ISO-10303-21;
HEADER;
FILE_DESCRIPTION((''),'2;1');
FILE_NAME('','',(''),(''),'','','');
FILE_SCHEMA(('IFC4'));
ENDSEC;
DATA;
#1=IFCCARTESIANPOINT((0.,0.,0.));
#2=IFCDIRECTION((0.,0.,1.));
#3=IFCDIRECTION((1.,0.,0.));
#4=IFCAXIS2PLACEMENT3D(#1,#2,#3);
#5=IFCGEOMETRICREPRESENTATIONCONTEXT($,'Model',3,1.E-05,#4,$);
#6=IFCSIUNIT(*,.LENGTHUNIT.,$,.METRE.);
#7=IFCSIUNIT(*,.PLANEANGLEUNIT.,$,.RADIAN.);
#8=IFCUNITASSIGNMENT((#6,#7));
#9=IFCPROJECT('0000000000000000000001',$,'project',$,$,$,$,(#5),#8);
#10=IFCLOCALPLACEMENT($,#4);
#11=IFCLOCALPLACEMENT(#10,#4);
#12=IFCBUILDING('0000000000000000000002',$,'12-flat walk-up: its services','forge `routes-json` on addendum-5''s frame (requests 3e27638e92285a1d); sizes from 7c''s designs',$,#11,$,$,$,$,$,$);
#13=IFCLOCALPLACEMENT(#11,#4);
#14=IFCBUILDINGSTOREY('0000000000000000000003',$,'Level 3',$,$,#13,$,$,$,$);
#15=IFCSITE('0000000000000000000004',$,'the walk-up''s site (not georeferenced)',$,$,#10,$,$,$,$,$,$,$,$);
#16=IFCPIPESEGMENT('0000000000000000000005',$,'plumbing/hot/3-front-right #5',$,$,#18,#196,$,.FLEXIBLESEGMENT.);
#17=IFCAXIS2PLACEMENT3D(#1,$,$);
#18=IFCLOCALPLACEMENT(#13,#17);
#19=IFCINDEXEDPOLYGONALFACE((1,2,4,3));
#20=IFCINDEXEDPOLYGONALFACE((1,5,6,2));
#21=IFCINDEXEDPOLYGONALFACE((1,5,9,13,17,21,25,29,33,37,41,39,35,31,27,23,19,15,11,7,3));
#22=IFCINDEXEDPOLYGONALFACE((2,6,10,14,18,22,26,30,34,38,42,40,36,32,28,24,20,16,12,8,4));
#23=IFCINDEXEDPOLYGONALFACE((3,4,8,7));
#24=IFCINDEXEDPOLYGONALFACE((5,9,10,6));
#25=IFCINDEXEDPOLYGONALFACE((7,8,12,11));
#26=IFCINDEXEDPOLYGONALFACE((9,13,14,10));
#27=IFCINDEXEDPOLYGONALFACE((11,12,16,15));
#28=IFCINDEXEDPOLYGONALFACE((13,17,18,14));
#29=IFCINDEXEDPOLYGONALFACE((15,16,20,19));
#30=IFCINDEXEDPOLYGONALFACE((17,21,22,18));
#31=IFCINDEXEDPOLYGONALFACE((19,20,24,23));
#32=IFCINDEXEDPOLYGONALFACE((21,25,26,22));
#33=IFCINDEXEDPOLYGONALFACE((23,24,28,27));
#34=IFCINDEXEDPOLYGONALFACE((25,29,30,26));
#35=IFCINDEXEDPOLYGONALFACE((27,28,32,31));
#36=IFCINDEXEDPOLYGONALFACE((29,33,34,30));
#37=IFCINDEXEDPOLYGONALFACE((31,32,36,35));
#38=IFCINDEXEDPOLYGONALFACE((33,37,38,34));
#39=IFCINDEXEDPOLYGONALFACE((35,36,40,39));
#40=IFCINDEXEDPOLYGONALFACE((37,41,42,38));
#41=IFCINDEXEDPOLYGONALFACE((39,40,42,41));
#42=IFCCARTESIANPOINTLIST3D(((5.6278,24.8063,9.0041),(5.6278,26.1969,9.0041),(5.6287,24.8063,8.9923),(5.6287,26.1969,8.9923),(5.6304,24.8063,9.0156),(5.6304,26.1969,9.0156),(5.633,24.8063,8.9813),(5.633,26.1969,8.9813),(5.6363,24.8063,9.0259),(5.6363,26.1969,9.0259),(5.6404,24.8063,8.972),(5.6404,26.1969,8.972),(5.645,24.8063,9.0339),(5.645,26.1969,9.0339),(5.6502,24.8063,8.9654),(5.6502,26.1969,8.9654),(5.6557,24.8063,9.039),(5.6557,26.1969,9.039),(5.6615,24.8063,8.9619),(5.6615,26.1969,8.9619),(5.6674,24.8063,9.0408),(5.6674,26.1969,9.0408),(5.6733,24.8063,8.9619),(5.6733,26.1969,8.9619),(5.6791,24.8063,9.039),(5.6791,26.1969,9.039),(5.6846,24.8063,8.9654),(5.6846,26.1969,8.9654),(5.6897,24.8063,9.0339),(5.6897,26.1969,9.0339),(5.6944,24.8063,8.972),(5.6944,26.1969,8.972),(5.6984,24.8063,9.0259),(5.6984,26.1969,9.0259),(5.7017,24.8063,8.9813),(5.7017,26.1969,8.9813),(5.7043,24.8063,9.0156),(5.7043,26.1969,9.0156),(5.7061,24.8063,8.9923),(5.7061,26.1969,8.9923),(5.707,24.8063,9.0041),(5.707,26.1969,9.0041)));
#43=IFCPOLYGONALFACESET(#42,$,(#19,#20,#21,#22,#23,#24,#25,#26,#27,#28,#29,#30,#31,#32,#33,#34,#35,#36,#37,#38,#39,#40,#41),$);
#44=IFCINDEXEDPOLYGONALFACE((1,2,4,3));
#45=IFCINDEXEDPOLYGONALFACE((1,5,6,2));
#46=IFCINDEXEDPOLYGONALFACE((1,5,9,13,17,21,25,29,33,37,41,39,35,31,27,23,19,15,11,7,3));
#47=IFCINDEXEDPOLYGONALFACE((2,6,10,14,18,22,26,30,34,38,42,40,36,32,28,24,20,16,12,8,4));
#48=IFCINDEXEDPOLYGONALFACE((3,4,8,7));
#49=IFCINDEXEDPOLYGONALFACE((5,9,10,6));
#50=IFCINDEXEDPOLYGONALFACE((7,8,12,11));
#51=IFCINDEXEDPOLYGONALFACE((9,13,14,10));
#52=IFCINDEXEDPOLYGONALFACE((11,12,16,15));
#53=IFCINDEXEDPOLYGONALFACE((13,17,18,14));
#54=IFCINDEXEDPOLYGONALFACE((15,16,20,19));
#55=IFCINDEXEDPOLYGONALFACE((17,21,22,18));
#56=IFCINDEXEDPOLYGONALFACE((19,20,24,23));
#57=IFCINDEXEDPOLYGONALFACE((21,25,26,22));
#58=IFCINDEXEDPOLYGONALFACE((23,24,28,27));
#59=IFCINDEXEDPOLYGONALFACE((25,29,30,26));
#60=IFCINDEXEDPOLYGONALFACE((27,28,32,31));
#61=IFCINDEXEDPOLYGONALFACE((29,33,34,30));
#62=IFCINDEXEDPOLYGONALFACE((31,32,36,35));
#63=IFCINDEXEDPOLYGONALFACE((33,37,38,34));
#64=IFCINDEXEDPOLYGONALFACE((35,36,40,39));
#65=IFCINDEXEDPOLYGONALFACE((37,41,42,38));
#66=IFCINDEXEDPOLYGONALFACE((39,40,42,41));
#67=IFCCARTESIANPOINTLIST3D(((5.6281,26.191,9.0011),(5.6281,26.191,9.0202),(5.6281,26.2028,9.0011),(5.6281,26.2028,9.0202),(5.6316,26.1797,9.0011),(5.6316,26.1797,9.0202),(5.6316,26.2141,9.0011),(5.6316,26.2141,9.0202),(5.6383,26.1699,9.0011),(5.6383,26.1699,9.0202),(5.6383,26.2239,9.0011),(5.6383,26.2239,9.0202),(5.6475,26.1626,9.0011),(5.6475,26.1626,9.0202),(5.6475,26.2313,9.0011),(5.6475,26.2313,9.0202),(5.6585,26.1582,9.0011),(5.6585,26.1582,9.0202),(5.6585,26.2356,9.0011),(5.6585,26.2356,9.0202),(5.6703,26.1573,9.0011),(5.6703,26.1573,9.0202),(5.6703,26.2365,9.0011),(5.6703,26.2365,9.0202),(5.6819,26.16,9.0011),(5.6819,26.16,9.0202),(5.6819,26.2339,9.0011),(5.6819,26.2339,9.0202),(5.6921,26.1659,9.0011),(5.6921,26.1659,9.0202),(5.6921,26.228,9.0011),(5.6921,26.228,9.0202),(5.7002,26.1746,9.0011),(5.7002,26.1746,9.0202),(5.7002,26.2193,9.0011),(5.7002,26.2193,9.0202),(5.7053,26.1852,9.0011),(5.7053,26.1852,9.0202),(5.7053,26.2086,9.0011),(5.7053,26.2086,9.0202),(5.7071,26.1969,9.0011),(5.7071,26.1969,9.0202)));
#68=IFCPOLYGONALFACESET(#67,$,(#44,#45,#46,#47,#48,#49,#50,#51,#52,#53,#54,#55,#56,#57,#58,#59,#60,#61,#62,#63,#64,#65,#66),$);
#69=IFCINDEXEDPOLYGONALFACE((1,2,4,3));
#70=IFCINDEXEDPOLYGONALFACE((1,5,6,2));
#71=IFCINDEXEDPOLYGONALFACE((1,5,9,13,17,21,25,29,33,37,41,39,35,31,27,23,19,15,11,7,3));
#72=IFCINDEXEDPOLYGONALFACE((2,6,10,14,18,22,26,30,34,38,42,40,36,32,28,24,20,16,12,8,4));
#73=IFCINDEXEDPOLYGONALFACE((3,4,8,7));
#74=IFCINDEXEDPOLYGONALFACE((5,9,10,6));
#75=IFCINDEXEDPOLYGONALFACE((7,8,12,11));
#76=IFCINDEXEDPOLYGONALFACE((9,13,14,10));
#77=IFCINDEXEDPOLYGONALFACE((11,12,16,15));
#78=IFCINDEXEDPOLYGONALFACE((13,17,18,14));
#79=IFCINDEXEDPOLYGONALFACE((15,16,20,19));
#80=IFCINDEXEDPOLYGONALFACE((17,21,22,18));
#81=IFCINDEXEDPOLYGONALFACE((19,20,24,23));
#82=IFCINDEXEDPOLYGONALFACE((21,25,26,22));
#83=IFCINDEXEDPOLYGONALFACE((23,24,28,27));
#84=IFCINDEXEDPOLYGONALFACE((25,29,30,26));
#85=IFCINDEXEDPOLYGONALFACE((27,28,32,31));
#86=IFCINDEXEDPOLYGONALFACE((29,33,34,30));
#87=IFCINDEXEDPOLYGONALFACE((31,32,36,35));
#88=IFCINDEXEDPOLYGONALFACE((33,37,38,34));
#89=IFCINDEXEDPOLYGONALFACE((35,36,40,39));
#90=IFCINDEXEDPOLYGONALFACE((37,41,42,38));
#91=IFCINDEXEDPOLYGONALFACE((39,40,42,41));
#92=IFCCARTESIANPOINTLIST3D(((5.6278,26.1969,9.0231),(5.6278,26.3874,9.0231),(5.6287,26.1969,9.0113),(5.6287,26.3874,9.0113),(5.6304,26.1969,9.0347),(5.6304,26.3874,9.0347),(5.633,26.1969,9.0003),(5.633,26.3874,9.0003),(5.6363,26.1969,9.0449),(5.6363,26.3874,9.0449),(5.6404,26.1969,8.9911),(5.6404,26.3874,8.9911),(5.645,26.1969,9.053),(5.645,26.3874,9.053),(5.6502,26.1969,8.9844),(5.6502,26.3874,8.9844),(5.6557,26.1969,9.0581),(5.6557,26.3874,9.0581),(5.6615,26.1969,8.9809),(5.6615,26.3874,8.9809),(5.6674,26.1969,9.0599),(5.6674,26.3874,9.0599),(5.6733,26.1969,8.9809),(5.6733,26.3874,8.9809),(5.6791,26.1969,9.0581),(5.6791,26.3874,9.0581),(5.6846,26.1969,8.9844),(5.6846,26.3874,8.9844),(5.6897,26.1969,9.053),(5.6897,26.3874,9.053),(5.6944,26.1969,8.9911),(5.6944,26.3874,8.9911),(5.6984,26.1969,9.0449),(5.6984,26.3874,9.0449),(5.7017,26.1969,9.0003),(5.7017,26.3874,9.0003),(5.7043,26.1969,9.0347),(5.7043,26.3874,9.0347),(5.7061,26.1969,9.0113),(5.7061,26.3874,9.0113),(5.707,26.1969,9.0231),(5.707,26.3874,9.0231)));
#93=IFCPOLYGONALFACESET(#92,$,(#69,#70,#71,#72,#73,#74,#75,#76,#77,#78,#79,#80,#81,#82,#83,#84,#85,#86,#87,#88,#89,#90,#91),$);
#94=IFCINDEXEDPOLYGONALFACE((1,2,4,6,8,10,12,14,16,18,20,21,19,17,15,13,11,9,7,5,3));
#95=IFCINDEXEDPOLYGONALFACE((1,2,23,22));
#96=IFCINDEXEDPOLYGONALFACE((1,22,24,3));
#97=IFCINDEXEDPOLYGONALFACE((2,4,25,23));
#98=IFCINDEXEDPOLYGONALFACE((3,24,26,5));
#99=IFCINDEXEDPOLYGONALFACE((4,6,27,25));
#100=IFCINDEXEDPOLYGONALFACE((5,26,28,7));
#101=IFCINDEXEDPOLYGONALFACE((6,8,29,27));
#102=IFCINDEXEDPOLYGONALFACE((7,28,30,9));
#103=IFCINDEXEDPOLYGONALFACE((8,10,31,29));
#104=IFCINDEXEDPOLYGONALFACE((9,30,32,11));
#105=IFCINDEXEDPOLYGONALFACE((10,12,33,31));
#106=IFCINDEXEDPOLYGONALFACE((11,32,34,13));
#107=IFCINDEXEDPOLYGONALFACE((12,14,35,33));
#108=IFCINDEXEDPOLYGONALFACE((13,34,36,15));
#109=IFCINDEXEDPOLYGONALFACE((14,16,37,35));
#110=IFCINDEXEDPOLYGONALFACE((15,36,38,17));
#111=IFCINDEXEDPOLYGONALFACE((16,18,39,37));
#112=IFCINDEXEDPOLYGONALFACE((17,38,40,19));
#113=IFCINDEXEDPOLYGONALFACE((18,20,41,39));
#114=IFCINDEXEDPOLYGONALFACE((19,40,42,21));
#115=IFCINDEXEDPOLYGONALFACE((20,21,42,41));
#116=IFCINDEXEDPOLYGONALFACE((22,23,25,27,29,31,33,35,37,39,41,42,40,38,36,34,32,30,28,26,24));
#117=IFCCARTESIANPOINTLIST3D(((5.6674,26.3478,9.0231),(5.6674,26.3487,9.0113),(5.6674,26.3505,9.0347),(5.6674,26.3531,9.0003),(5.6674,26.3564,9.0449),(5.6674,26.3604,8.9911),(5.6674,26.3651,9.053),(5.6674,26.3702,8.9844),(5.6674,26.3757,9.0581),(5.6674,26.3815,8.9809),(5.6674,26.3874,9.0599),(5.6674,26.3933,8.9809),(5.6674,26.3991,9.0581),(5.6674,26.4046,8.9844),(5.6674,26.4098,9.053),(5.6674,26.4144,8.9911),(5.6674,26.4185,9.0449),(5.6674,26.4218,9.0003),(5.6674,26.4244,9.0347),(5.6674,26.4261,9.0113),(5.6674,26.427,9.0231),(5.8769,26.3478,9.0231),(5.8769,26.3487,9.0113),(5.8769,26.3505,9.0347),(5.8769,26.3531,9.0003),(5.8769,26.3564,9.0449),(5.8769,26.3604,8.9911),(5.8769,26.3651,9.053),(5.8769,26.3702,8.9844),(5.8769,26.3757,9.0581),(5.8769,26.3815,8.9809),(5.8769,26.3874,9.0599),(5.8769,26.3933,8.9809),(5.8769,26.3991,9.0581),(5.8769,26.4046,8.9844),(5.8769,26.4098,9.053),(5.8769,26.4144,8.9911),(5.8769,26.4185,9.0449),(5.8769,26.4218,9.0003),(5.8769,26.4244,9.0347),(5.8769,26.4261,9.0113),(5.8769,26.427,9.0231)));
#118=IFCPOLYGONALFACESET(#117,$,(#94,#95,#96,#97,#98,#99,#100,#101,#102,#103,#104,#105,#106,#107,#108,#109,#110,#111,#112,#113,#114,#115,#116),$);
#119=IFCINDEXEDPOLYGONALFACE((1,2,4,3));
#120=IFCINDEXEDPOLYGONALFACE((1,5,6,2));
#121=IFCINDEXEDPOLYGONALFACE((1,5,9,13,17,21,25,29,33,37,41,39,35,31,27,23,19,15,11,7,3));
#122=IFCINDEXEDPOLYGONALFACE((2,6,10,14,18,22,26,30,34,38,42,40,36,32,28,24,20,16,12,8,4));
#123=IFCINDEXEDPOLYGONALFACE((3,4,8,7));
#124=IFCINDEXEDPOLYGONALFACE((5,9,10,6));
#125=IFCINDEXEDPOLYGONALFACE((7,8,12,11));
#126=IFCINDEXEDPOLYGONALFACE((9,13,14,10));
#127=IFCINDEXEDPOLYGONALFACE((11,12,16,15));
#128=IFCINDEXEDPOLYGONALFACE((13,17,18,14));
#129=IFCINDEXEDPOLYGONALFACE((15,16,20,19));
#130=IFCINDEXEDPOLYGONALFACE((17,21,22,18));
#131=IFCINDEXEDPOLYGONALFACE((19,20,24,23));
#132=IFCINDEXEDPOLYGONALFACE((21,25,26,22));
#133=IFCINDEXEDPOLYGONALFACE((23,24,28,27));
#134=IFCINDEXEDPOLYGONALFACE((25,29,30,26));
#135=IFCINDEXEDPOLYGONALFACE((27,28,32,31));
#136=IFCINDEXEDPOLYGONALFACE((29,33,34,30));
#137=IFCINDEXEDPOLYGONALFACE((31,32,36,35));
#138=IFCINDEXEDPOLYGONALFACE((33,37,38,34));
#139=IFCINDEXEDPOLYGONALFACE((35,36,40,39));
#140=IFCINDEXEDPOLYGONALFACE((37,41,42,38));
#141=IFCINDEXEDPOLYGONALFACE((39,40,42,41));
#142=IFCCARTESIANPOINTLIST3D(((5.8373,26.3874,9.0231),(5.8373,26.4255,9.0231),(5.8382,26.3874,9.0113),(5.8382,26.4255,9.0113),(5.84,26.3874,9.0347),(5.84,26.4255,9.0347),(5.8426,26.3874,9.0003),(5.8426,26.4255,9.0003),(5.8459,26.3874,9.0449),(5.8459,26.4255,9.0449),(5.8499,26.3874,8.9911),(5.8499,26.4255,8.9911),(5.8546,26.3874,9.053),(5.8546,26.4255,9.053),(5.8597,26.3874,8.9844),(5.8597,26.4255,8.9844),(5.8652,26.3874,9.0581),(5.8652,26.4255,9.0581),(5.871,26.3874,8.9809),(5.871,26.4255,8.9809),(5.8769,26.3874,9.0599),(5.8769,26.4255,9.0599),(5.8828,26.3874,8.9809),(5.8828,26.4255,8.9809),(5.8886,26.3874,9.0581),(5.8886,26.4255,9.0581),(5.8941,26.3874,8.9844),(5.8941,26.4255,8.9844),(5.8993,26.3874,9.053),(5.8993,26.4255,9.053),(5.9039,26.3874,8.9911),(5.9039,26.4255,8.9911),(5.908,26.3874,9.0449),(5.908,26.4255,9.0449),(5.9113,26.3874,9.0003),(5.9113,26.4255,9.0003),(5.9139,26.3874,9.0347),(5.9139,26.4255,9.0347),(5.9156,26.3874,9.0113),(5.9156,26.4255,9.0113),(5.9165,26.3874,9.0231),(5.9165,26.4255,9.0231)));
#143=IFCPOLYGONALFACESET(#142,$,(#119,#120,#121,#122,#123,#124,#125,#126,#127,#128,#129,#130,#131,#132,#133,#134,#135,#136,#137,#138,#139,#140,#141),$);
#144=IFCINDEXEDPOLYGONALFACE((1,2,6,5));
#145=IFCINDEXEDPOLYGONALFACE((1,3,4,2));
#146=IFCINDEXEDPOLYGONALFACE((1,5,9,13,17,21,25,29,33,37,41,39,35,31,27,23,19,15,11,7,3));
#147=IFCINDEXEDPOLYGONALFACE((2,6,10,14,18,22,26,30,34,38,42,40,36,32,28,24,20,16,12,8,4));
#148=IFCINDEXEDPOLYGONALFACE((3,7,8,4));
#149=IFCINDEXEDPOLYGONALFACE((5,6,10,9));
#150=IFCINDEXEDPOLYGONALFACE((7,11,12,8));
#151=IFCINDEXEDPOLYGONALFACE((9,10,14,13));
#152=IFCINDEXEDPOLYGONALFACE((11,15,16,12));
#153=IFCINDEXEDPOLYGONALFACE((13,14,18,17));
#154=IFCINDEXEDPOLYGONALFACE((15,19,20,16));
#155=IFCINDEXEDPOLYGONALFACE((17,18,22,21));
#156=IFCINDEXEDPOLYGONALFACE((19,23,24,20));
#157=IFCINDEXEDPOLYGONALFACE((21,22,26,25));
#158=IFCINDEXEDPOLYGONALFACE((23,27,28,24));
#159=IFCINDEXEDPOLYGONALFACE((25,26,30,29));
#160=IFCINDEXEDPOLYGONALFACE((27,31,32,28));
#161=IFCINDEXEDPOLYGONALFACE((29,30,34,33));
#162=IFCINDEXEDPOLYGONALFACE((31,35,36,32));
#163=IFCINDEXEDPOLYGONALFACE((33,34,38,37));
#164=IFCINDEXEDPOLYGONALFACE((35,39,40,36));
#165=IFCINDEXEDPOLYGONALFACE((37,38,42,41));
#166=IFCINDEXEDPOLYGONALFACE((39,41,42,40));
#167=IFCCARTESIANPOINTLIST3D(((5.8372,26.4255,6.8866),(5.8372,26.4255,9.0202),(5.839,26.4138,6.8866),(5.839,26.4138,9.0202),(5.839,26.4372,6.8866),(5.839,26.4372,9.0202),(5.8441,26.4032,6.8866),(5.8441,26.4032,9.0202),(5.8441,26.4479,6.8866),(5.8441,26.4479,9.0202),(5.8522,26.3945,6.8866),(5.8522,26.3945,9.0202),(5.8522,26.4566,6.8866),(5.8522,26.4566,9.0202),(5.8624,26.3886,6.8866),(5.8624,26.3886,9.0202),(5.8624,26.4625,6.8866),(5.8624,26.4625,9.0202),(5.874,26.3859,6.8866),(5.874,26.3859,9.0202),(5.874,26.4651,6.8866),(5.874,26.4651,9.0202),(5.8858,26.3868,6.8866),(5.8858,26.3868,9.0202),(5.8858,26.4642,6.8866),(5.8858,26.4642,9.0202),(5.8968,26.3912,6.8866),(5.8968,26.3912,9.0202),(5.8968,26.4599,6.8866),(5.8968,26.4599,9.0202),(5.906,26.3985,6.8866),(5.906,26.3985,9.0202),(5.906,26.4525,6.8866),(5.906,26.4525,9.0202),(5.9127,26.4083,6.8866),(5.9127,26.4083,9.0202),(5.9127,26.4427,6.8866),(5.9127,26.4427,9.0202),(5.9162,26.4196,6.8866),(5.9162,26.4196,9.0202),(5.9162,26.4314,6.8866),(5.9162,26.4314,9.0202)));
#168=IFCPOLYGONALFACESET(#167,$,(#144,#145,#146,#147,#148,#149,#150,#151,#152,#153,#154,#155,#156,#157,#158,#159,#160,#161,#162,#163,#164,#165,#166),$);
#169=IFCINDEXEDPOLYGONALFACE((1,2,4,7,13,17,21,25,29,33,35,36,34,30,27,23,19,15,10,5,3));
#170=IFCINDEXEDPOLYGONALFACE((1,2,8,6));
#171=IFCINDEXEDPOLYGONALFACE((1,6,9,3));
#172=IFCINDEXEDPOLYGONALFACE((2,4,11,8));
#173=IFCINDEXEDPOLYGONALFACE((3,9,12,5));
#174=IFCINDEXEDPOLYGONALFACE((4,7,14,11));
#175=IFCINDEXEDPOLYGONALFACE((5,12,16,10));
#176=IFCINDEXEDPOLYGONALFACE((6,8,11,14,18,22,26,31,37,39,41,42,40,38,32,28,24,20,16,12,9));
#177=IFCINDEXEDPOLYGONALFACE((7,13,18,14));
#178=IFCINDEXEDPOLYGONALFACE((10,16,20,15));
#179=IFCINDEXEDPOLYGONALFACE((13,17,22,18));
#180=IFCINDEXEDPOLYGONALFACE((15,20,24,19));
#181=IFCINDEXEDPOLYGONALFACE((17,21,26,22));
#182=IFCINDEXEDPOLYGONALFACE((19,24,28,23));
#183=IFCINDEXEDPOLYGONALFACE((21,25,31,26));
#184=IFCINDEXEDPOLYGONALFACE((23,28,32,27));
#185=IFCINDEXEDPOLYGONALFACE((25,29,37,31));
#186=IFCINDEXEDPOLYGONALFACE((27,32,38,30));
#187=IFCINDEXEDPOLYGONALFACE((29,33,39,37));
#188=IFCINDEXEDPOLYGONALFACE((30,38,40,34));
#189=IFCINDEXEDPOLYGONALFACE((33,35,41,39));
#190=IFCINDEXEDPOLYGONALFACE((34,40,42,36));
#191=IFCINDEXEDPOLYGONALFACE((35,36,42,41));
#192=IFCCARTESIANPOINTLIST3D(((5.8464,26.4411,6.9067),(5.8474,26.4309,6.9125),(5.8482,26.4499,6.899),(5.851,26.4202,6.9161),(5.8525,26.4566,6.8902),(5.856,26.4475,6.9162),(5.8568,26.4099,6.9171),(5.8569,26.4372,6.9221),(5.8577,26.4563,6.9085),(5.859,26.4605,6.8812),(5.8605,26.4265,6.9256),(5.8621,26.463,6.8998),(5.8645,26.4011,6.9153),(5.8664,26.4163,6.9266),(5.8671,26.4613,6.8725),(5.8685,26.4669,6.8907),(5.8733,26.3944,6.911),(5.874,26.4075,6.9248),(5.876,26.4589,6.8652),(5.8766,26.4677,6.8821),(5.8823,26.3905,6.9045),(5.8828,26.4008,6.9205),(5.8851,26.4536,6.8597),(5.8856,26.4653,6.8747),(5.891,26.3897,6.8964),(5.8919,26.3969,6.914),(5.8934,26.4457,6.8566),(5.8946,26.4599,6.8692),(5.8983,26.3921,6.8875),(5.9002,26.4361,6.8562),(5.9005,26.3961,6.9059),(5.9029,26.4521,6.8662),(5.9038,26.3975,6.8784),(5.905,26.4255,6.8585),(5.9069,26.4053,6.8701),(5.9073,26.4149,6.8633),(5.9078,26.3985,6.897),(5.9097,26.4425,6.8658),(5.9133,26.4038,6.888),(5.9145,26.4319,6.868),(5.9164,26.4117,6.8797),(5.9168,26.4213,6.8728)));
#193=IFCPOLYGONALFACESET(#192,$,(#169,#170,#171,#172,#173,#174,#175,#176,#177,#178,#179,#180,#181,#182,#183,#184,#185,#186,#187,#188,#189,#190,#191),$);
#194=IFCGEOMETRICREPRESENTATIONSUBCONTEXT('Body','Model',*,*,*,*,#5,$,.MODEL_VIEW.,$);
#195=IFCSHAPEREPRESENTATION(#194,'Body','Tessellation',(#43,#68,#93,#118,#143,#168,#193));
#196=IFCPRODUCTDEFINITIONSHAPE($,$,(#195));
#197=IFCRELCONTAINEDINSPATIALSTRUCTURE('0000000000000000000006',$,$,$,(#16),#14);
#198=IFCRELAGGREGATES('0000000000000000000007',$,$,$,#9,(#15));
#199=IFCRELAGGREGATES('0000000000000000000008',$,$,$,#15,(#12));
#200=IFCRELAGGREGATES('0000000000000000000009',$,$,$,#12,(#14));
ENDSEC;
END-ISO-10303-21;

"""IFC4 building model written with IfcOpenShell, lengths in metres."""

from ifc_helpers import new_model, entity, si_unit, frame, origin_with_axes, place, context, subcontext, project, spatial, element, save


model = new_model("IFC4")

# Units and contexts
model_context = context("Model", 3, precision=1e-05, world=origin_with_axes())
body_context = subcontext(model_context, "Body", "Model", "MODEL_VIEW")
ifc_project = project(units=[si_unit("LENGTHUNIT", "METRE"), si_unit("PLANEANGLEUNIT", "RADIAN")], contexts=[model_context])

# Site, building, storey
site_placement = place(None, origin_with_axes())
site = spatial("IfcSite", under=ifc_project, at=site_placement, Name="the walk-up's site (not georeferenced)")
building_placement = place(site_placement, origin_with_axes())
building = spatial("IfcBuilding", under=site, at=building_placement, Name="12-flat walk-up: its services", Description="forge `routes-json` on addendum-5's frame (requests 3e27638e92285a1d); sizes from 7c's designs")
storey_placement = place(building_placement, origin_with_axes())
storey = spatial("IfcBuildingStorey", under=building, at=storey_placement, Name="Level 3")

# Pipe segment
pipe_segment_1_placement = place(storey_placement, frame((5.6674, 24.8063, 9.0011), z_axis=(0.0, 0.0, 1.0), x_axis=(1.0, 0.0, 0.0)))
element("IfcPipeSegment", 1, at=pipe_segment_1_placement, inside=storey, Name="plumbing/hot/3-front-right #5", PredefinedType="FLEXIBLESEGMENT", context=body_context, shape_type="AdvancedSweptSolid", body=[
    entity("IfcSweptDiskSolid", entity("IfcPolyline", [entity("IfcCartesianPoint", [0.0, 0.0, 0.0]), entity("IfcCartesianPoint", [0.0, 1.3906, 0.0])]), 0.0397),
    entity("IfcSweptDiskSolid", entity("IfcPolyline", [entity("IfcCartesianPoint", [0.0, 1.3906, 0.0]), entity("IfcCartesianPoint", [0.0, 1.3906, 0.0191])]), 0.0397),
    entity("IfcSweptDiskSolid", entity("IfcPolyline", [entity("IfcCartesianPoint", [0.0, 1.3906, 0.0191]), entity("IfcCartesianPoint", [0.0, 1.5811, 0.0191])]), 0.0397),
    entity("IfcSweptDiskSolid", entity("IfcPolyline", [entity("IfcCartesianPoint", [0.0, 1.5811, 0.0191]), entity("IfcCartesianPoint", [0.2096, 1.5811, 0.0191])]), 0.0397),
    entity("IfcSweptDiskSolid", entity("IfcPolyline", [entity("IfcCartesianPoint", [0.2096, 1.5811, 0.0191]), entity("IfcCartesianPoint", [0.2096, 1.6192, 0.0191])]), 0.0397),
    entity("IfcSweptDiskSolid", entity("IfcPolyline", [entity("IfcCartesianPoint", [0.2096, 1.6192, 0.0191]), entity("IfcCartesianPoint", [0.2096, 1.6192, -2.1146])]), 0.0397),
    entity("IfcSweptDiskSolid", entity("IfcPolyline", [entity("IfcCartesianPoint", [0.2096, 1.6192, -2.1146]), entity("IfcCartesianPoint", [0.2191, 1.6256, -2.105])]), 0.0397),
])

save(model, "model.ifc")
